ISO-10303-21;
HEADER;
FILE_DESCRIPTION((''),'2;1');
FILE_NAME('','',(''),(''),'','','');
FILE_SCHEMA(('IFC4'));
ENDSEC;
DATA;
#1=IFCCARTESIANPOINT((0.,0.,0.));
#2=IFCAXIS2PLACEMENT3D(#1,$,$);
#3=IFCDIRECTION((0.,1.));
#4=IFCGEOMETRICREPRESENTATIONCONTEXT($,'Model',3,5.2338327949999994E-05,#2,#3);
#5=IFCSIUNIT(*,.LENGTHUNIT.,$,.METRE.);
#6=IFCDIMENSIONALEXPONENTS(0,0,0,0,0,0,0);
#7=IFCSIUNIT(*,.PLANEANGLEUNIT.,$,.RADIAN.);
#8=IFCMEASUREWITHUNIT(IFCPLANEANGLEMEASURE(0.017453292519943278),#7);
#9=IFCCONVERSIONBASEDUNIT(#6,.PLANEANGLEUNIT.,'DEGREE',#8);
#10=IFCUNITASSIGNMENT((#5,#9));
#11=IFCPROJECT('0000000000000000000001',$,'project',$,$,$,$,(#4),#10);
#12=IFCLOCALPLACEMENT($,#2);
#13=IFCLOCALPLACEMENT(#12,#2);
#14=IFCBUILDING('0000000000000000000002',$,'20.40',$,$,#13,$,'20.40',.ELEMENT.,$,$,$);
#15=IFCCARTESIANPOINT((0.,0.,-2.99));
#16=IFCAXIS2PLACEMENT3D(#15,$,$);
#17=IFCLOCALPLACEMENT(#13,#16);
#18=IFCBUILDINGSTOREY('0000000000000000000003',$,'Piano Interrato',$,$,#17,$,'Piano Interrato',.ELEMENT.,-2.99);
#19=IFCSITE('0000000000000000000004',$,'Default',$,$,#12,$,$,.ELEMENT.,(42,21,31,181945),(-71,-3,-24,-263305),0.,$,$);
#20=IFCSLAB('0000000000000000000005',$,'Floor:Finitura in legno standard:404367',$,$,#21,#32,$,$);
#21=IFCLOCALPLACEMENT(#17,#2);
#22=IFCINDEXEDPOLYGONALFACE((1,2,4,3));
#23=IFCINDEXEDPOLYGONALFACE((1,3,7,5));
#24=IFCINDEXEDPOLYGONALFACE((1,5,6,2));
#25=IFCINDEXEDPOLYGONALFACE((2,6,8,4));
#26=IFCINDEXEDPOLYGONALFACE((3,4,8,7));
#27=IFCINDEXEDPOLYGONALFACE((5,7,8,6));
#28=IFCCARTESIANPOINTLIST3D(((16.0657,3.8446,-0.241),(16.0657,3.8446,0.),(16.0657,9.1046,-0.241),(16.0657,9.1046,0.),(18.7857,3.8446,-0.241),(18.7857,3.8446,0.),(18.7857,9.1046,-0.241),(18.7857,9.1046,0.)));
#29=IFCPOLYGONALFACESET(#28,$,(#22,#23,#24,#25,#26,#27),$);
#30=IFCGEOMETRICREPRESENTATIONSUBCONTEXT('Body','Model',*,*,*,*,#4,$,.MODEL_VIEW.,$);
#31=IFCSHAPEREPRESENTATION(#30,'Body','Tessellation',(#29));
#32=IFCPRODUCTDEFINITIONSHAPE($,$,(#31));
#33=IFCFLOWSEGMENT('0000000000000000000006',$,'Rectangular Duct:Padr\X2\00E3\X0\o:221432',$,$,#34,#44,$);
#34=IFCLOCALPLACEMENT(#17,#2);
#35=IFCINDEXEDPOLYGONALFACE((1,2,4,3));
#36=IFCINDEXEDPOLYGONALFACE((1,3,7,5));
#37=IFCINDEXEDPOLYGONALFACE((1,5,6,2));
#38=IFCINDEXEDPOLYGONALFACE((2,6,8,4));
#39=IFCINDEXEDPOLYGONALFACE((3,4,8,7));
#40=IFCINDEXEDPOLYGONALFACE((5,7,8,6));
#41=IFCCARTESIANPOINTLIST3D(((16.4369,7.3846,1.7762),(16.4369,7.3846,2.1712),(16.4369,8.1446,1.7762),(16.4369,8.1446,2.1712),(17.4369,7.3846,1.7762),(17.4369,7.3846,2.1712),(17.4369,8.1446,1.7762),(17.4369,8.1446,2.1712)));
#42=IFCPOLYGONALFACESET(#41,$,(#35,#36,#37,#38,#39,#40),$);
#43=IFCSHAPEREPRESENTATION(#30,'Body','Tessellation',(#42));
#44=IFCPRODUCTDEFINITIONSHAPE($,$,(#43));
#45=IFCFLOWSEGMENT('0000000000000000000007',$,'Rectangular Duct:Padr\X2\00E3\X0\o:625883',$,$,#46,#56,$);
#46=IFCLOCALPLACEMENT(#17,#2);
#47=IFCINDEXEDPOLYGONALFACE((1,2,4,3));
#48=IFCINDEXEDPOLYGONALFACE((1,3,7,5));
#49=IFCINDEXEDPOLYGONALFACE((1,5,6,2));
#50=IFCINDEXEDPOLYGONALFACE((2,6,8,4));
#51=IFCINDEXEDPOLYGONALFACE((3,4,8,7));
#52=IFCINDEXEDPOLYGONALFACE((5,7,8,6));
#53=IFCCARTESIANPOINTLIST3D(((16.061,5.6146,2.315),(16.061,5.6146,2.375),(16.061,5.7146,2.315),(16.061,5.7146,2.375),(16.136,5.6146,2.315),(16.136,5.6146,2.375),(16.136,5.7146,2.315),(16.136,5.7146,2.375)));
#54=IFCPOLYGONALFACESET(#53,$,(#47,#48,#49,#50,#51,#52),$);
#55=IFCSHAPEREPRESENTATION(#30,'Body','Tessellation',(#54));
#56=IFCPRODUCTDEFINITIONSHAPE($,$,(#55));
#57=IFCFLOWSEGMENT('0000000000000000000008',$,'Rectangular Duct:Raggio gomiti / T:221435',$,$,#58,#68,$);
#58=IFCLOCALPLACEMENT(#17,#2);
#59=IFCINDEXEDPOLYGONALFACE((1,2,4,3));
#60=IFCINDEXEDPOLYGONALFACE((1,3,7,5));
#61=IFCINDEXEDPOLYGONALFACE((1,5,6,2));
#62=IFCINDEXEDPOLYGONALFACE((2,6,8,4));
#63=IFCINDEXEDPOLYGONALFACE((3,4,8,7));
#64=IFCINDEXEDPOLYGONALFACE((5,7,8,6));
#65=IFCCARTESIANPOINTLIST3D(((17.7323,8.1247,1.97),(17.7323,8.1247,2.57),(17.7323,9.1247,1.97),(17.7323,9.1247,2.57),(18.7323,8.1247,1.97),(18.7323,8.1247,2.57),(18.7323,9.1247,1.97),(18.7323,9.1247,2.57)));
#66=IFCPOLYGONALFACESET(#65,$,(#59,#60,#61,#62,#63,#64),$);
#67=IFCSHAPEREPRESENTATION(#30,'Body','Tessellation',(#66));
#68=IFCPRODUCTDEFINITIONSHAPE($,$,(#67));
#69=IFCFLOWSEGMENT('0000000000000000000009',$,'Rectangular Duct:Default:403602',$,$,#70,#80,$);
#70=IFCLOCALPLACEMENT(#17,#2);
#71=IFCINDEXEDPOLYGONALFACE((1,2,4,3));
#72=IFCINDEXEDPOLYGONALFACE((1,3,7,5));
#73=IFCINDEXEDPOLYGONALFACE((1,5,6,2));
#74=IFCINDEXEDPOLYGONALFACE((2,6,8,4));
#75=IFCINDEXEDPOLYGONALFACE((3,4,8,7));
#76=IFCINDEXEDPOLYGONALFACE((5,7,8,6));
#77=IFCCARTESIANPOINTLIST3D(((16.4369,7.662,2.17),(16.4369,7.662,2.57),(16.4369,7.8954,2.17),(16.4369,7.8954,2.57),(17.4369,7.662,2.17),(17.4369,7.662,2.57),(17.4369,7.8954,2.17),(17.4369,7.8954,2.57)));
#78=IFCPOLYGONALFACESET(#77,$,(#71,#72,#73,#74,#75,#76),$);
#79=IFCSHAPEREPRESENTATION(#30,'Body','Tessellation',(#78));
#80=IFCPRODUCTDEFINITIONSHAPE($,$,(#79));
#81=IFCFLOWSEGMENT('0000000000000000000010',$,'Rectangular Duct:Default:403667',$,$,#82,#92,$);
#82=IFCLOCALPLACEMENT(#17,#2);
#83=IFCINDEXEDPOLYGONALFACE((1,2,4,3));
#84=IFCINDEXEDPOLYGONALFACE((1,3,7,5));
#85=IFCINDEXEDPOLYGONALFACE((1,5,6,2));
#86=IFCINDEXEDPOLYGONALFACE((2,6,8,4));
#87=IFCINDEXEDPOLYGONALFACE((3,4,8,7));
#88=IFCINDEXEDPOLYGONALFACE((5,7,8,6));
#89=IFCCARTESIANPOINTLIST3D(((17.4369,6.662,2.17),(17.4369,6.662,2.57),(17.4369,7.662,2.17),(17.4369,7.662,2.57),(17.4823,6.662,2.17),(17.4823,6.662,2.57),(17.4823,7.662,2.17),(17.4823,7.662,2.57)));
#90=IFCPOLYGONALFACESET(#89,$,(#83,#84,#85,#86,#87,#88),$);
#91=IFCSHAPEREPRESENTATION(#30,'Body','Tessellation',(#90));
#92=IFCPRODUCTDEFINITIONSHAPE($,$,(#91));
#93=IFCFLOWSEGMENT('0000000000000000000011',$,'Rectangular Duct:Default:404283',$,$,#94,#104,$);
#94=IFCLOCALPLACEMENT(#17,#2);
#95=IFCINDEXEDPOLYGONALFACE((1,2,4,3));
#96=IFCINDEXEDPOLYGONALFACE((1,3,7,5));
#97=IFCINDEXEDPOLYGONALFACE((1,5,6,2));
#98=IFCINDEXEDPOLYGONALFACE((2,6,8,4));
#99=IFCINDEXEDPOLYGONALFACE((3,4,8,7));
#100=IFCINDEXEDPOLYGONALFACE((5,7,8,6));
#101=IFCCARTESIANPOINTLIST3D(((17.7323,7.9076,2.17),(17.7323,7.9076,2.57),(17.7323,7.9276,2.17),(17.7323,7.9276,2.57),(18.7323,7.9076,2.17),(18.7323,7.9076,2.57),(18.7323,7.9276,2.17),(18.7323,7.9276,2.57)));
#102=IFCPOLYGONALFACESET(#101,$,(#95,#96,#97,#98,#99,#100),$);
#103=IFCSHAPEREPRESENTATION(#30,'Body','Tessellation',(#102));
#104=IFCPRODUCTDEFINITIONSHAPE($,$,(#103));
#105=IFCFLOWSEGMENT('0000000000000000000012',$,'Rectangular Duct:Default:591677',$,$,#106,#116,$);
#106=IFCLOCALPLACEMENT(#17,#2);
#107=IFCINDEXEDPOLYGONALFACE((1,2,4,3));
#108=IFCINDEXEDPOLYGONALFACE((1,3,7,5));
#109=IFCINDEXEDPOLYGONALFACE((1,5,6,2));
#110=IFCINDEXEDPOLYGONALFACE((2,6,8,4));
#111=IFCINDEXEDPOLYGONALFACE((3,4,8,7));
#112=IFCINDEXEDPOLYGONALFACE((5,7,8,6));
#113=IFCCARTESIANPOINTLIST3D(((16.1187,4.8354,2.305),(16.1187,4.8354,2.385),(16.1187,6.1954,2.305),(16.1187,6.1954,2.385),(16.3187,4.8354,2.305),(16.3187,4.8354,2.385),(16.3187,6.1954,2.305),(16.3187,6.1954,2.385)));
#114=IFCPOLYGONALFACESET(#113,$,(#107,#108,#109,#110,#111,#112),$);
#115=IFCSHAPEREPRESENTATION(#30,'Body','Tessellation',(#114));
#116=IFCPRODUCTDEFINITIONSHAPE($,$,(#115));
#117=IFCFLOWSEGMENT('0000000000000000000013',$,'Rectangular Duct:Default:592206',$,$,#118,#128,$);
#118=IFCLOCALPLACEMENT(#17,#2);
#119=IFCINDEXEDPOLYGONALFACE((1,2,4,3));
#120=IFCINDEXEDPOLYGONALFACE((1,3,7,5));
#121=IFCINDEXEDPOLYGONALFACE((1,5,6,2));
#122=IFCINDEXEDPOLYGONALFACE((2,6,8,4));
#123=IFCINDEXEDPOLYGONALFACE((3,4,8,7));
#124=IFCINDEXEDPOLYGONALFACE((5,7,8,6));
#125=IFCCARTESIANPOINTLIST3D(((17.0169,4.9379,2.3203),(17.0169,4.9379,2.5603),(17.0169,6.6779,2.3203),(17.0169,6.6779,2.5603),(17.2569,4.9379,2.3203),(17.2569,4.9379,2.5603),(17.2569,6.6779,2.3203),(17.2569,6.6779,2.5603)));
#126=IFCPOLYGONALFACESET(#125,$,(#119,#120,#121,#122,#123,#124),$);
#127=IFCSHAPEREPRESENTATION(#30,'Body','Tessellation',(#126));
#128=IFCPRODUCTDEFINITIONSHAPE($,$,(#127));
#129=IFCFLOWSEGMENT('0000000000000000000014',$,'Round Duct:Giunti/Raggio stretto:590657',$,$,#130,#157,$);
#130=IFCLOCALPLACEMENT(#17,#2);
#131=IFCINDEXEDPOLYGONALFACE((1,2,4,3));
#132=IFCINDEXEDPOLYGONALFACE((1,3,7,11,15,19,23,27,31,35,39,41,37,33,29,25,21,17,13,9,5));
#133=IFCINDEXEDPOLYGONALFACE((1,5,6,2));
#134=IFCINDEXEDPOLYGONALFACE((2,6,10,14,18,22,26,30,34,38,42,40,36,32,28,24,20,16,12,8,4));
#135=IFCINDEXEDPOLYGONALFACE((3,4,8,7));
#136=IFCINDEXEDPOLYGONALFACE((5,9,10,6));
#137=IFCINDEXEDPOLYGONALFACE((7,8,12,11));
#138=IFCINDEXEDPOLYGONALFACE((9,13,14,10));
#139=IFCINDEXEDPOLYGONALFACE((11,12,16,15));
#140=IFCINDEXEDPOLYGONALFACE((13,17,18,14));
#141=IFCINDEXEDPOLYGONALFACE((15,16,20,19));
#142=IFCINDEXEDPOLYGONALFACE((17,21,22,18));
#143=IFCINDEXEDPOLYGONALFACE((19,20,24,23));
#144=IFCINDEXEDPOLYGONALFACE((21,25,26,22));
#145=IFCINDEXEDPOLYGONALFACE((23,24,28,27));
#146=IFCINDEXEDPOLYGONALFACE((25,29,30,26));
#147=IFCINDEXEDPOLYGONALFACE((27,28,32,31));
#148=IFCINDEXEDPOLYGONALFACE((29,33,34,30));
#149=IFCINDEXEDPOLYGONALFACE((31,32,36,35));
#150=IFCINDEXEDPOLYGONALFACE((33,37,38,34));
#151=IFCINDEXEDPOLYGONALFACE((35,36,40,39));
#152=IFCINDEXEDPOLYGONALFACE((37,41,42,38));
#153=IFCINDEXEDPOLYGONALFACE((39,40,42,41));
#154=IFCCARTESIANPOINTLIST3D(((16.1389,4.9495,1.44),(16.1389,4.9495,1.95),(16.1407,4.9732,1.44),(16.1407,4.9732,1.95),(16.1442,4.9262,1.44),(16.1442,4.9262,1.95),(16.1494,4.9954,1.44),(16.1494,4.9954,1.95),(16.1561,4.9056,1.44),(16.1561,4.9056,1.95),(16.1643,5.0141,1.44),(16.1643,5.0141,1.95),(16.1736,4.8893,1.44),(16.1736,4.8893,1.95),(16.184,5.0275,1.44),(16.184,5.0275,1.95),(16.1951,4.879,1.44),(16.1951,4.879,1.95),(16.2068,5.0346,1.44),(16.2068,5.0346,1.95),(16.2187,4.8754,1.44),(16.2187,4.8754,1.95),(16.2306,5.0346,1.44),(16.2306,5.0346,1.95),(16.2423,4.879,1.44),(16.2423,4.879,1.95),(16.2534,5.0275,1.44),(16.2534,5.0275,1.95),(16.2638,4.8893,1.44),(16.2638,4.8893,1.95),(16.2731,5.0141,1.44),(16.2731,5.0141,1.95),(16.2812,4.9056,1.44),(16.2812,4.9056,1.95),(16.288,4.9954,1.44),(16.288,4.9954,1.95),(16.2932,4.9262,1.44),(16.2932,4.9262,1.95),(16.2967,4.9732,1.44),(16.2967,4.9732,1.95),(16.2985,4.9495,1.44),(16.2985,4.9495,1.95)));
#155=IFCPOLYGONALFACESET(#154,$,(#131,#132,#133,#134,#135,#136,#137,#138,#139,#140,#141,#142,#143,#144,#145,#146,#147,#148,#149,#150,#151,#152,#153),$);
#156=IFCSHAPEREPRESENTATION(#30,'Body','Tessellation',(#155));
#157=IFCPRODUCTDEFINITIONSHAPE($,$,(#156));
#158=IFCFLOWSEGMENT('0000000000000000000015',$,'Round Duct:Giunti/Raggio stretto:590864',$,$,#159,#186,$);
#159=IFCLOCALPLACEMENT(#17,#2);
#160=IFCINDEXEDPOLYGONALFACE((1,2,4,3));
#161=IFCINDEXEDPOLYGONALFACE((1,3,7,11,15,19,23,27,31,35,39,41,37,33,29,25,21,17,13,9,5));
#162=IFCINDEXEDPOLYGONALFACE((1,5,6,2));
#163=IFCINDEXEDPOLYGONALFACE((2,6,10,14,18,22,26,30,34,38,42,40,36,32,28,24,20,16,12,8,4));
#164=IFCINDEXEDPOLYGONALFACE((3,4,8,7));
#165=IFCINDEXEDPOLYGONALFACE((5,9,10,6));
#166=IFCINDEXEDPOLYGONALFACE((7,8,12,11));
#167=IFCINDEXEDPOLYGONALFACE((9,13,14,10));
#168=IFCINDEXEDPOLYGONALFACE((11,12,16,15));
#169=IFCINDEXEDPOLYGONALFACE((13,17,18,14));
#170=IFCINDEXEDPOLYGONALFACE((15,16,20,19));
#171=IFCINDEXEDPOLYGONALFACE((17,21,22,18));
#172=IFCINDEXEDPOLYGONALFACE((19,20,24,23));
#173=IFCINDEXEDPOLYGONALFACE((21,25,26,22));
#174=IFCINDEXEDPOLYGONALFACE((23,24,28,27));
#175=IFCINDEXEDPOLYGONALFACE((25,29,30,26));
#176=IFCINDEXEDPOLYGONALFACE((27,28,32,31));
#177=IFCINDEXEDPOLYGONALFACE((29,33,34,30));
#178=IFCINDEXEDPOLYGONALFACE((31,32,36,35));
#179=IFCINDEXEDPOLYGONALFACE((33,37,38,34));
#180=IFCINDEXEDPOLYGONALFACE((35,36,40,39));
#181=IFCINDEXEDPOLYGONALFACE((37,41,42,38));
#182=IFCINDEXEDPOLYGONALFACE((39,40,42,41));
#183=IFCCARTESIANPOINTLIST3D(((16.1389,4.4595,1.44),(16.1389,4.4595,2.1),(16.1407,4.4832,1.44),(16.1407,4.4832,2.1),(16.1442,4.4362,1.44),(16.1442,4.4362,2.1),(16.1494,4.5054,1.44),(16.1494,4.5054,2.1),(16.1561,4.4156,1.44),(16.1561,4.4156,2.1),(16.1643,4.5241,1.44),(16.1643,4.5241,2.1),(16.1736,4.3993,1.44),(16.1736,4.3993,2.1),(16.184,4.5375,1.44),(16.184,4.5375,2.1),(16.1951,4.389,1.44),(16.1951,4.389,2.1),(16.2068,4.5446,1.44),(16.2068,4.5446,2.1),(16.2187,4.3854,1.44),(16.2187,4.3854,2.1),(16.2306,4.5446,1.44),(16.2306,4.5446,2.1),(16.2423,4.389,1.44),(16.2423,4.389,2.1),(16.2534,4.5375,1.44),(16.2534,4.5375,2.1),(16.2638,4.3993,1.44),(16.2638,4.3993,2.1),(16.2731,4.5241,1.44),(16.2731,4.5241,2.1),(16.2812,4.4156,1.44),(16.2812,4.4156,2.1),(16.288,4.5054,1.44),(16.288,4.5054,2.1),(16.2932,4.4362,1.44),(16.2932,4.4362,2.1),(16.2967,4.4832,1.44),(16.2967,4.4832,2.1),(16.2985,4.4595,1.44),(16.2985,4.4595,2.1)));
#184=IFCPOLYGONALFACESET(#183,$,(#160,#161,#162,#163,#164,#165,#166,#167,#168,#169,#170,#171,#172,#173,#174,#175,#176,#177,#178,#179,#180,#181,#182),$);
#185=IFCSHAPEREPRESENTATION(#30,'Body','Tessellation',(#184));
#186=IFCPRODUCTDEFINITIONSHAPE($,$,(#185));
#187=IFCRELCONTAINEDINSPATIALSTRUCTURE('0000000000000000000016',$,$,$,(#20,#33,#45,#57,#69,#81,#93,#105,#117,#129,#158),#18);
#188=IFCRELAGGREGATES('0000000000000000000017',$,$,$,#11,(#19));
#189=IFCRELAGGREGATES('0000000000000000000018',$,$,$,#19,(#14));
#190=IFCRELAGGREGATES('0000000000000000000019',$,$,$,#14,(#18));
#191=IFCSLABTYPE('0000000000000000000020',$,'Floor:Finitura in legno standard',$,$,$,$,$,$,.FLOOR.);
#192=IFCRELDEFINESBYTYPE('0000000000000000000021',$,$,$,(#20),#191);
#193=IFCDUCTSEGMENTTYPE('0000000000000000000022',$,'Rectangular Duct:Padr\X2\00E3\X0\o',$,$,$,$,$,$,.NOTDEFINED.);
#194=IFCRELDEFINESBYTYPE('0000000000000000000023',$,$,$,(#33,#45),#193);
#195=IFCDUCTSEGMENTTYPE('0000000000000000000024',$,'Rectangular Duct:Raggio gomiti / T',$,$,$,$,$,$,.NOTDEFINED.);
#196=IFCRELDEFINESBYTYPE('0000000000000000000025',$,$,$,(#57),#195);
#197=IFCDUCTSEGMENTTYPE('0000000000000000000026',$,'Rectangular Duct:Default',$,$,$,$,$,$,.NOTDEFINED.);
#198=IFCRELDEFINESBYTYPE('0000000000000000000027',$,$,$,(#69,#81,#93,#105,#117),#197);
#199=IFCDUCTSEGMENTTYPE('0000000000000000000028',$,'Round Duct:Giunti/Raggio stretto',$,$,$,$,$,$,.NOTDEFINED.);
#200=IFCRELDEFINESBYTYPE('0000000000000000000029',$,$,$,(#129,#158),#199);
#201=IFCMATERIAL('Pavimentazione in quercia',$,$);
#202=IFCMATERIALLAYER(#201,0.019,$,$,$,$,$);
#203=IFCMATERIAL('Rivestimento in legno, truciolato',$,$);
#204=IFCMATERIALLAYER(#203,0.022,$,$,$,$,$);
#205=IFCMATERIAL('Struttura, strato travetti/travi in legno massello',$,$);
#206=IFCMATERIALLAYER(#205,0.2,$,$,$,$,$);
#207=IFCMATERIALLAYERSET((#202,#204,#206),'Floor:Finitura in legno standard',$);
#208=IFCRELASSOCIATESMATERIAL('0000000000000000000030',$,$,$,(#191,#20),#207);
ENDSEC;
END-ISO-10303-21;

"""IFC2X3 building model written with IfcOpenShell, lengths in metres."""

from ifc_helpers import new_model, entity, si_unit, converted_unit, direction, frame, frame_2d, origin, origin_2d_with_axis, place, context, subcontext, project, spatial, rectangle, circle, extrude, material, layer, layer_set, layer_usage, type_object, element, save


model = new_model("IFC2X3")

# Units and contexts
model_context = context("Model", 3, precision=5.2338327949999994e-05, world=origin(), true_north=direction((0.0, 1.0)))
body_context = subcontext(model_context, "Body", "Model", "MODEL_VIEW")
ifc_project = project(units=[si_unit("LENGTHUNIT", "METRE"), converted_unit("PLANEANGLEUNIT", "DEGREE", entity("IfcPlaneAngleMeasure", 0.017453292519943278), si_unit("PLANEANGLEUNIT", "RADIAN"), dimensions=[0, 0, 0, 0, 0, 0, 0])], contexts=[model_context])

# Site, building, storey
site_placement = place(None, origin())
site = spatial("IfcSite", under=ifc_project, at=site_placement, Name="Default", CompositionType="ELEMENT", RefLatitude=(42, 21, 31, 181945), RefLongitude=(-71, -3, -24, -263305), RefElevation=0.0)
building_placement = place(site_placement, origin())
building = spatial("IfcBuilding", under=site, at=building_placement, Name="20.40", LongName="20.40", CompositionType="ELEMENT")
storey_placement = place(building_placement, frame((0.0, 0.0, -2.99)))
storey = spatial("IfcBuildingStorey", under=building, at=storey_placement, Name="Piano Interrato", LongName="Piano Interrato", CompositionType="ELEMENT", Elevation=-2.99)

# Slab
ifc_material_1 = material(Name="Pavimentazione in quercia")
ifc_layer_1 = layer(ifc_material_1, 0.019)
ifc_material_2 = material(Name="Rivestimento in legno, truciolato")
ifc_layer_2 = layer(ifc_material_2, 0.022)
ifc_material_3 = material(Name="Struttura, strato travetti/travi in legno massello")
ifc_layer_3 = layer(ifc_material_3, 0.2)
ifc_layer_set = layer_set([ifc_layer_1, ifc_layer_2, ifc_layer_3], Name="Floor:Finitura in legno standard")
ifc_layer_usage = layer_usage(ifc_layer_set, "AXIS3", "POSITIVE", 0.0)
slab_type = type_object("IfcSlabType", Name="Floor:Finitura in legno standard", PredefinedType="FLOOR", material=ifc_layer_set)
slab_placement = place(storey_placement, origin())
element("IfcSlab", 1, at=slab_placement, inside=storey, type_object=slab_type, material=ifc_layer_usage, Name="Floor:Finitura in legno standard:404367", context=body_context, shape_type="SweptSolid", body=[
    extrude(rectangle(XDim=5.26, YDim=2.72, at=frame_2d((0.0, 0.0), x_axis=(1.0, 0.0))), frame((17.4257, 6.4746, 0.0), z_axis=(0.0, 0.0, -1.0), x_axis=(0.0, 1.0, 0.0)), (0.0, 0.0, 1.0), 0.241),
])

# Flow segments
duct_segment_type_1 = type_object("IfcDuctSegmentType", Name="Rectangular Duct:Padrão", PredefinedType="NOTDEFINED")
flow_segment_1_placement = place(storey_placement, origin())
element("IfcFlowSegment", 2, at=flow_segment_1_placement, inside=storey, type_object=duct_segment_type_1, Name="Rectangular Duct:Padrão:221432", context=body_context, shape_type="SweptSolid", body=[
    extrude(rectangle(XDim=0.76, YDim=1.0, at=origin_2d_with_axis()), frame((16.9369, 7.7646, 1.7762), z_axis=(0.0, 0.0, 1.0), x_axis=(0.0, 1.0, 0.0)), (0.0, 0.0, 1.0), 0.395),
])
flow_segment_2_placement = place(storey_placement, origin())
element("IfcFlowSegment", 3, at=flow_segment_2_placement, inside=storey, type_object=duct_segment_type_1, Name="Rectangular Duct:Padrão:625883", context=body_context, shape_type="SweptSolid", body=[
    extrude(rectangle(XDim=0.075, YDim=0.1, at=frame_2d((0.0, 0.0), x_axis=(1.0, 0.0))), frame((16.0985, 5.6646, 2.315)), (0.0, 0.0, 1.0), 0.06),
])
duct_segment_type_2 = type_object("IfcDuctSegmentType", Name="Rectangular Duct:Raggio gomiti / T", PredefinedType="NOTDEFINED")
flow_segment_3_placement = place(storey_placement, origin())
element("IfcFlowSegment", 4, at=flow_segment_3_placement, inside=storey, type_object=duct_segment_type_2, Name="Rectangular Duct:Raggio gomiti / T:221435", context=body_context, shape_type="SweptSolid", body=[
    extrude(rectangle(XDim=1.0, YDim=1.0, at=frame_2d((0.0, 0.0), x_axis=(1.0, 0.0))), frame((18.2323, 8.6247, 1.97), z_axis=(0.0, 0.0, 1.0), x_axis=(0.0, 1.0, 0.0)), (0.0, 0.0, 1.0), 0.6),
])
duct_segment_type_3 = type_object("IfcDuctSegmentType", Name="Rectangular Duct:Default", PredefinedType="NOTDEFINED")
flow_segment_4_placement = place(storey_placement, origin())
element("IfcFlowSegment", 5, at=flow_segment_4_placement, inside=storey, type_object=duct_segment_type_3, Name="Rectangular Duct:Default:403602", context=body_context, shape_type="SweptSolid", body=[
    extrude(rectangle(XDim=0.2334, YDim=1.0, at=frame_2d((0.0, 0.0), x_axis=(1.0, 0.0))), frame((16.9369, 7.7787, 2.17), z_axis=(0.0, 0.0, 1.0), x_axis=(0.0, -1.0, 0.0)), (0.0, 0.0, 1.0), 0.4),
])
flow_segment_5_placement = place(storey_placement, origin())
element("IfcFlowSegment", 6, at=flow_segment_5_placement, inside=storey, type_object=duct_segment_type_3, Name="Rectangular Duct:Default:403667", context=body_context, shape_type="SweptSolid", body=[
    extrude(rectangle(XDim=0.0454, YDim=1.0, at=frame_2d((0.0, 0.0), x_axis=(1.0, 0.0))), frame((17.4596, 7.162, 2.17), z_axis=(0.0, 0.0, 1.0), x_axis=(-1.0, 0.0, 0.0)), (0.0, 0.0, 1.0), 0.4),
])
flow_segment_6_placement = place(storey_placement, origin())
element("IfcFlowSegment", 7, at=flow_segment_6_placement, inside=storey, type_object=duct_segment_type_3, Name="Rectangular Duct:Default:404283", context=body_context, shape_type="SweptSolid", body=[
    extrude(rectangle(XDim=0.02, YDim=1.0, at=frame_2d((0.0, 0.0), x_axis=(1.0, 0.0))), frame((18.2323, 7.9176, 2.17), z_axis=(0.0, 0.0, 1.0), x_axis=(0.0, -1.0, 0.0)), (0.0, 0.0, 1.0), 0.4),
])
flow_segment_7_placement = place(storey_placement, origin())
element("IfcFlowSegment", 8, at=flow_segment_7_placement, inside=storey, type_object=duct_segment_type_3, Name="Rectangular Duct:Default:591677", context=body_context, shape_type="SweptSolid", body=[
    extrude(rectangle(XDim=1.36, YDim=0.2, at=frame_2d((0.0, 0.0), x_axis=(1.0, 0.0))), frame((16.2187, 5.5154, 2.305), z_axis=(0.0, 0.0, 1.0), x_axis=(0.0, 1.0, 0.0)), (0.0, 0.0, 1.0), 0.08),
])
flow_segment_8_placement = place(storey_placement, origin())
element("IfcFlowSegment", 9, at=flow_segment_8_placement, inside=storey, type_object=duct_segment_type_3, Name="Rectangular Duct:Default:592206", context=body_context, shape_type="SweptSolid", body=[
    extrude(rectangle(XDim=1.74, YDim=0.24, at=frame_2d((0.0, 0.0), x_axis=(1.0, 0.0))), frame((17.1369, 5.8079, 2.3203), z_axis=(0.0, 0.0, 1.0), x_axis=(0.0, -1.0, 0.0)), (0.0, 0.0, 1.0), 0.24),
])
duct_segment_type_4 = type_object("IfcDuctSegmentType", Name="Round Duct:Giunti/Raggio stretto", PredefinedType="NOTDEFINED")
flow_segment_9_placement = place(storey_placement, origin())
element("IfcFlowSegment", 10, at=flow_segment_9_placement, inside=storey, type_object=duct_segment_type_4, Name="Round Duct:Giunti/Raggio stretto:590657", context=body_context, shape_type="SweptSolid", body=[
    extrude(circle(Radius=0.08, at=origin_2d_with_axis()), frame((16.2187, 4.9554, 1.44), z_axis=(0.0, 0.0, 1.0), x_axis=(0.0, -1.0, 0.0)), (0.0, 0.0, 1.0), 0.51),
])
flow_segment_10_placement = place(storey_placement, origin())
element("IfcFlowSegment", 11, at=flow_segment_10_placement, inside=storey, type_object=duct_segment_type_4, Name="Round Duct:Giunti/Raggio stretto:590864", context=body_context, shape_type="SweptSolid", body=[
    extrude(circle(Radius=0.08, at=origin_2d_with_axis()), frame((16.2187, 4.4654, 1.44), z_axis=(0.0, 0.0, 1.0), x_axis=(0.0, -1.0, 0.0)), (0.0, 0.0, 1.0), 0.66),
])

save(model, "model.ifc")
